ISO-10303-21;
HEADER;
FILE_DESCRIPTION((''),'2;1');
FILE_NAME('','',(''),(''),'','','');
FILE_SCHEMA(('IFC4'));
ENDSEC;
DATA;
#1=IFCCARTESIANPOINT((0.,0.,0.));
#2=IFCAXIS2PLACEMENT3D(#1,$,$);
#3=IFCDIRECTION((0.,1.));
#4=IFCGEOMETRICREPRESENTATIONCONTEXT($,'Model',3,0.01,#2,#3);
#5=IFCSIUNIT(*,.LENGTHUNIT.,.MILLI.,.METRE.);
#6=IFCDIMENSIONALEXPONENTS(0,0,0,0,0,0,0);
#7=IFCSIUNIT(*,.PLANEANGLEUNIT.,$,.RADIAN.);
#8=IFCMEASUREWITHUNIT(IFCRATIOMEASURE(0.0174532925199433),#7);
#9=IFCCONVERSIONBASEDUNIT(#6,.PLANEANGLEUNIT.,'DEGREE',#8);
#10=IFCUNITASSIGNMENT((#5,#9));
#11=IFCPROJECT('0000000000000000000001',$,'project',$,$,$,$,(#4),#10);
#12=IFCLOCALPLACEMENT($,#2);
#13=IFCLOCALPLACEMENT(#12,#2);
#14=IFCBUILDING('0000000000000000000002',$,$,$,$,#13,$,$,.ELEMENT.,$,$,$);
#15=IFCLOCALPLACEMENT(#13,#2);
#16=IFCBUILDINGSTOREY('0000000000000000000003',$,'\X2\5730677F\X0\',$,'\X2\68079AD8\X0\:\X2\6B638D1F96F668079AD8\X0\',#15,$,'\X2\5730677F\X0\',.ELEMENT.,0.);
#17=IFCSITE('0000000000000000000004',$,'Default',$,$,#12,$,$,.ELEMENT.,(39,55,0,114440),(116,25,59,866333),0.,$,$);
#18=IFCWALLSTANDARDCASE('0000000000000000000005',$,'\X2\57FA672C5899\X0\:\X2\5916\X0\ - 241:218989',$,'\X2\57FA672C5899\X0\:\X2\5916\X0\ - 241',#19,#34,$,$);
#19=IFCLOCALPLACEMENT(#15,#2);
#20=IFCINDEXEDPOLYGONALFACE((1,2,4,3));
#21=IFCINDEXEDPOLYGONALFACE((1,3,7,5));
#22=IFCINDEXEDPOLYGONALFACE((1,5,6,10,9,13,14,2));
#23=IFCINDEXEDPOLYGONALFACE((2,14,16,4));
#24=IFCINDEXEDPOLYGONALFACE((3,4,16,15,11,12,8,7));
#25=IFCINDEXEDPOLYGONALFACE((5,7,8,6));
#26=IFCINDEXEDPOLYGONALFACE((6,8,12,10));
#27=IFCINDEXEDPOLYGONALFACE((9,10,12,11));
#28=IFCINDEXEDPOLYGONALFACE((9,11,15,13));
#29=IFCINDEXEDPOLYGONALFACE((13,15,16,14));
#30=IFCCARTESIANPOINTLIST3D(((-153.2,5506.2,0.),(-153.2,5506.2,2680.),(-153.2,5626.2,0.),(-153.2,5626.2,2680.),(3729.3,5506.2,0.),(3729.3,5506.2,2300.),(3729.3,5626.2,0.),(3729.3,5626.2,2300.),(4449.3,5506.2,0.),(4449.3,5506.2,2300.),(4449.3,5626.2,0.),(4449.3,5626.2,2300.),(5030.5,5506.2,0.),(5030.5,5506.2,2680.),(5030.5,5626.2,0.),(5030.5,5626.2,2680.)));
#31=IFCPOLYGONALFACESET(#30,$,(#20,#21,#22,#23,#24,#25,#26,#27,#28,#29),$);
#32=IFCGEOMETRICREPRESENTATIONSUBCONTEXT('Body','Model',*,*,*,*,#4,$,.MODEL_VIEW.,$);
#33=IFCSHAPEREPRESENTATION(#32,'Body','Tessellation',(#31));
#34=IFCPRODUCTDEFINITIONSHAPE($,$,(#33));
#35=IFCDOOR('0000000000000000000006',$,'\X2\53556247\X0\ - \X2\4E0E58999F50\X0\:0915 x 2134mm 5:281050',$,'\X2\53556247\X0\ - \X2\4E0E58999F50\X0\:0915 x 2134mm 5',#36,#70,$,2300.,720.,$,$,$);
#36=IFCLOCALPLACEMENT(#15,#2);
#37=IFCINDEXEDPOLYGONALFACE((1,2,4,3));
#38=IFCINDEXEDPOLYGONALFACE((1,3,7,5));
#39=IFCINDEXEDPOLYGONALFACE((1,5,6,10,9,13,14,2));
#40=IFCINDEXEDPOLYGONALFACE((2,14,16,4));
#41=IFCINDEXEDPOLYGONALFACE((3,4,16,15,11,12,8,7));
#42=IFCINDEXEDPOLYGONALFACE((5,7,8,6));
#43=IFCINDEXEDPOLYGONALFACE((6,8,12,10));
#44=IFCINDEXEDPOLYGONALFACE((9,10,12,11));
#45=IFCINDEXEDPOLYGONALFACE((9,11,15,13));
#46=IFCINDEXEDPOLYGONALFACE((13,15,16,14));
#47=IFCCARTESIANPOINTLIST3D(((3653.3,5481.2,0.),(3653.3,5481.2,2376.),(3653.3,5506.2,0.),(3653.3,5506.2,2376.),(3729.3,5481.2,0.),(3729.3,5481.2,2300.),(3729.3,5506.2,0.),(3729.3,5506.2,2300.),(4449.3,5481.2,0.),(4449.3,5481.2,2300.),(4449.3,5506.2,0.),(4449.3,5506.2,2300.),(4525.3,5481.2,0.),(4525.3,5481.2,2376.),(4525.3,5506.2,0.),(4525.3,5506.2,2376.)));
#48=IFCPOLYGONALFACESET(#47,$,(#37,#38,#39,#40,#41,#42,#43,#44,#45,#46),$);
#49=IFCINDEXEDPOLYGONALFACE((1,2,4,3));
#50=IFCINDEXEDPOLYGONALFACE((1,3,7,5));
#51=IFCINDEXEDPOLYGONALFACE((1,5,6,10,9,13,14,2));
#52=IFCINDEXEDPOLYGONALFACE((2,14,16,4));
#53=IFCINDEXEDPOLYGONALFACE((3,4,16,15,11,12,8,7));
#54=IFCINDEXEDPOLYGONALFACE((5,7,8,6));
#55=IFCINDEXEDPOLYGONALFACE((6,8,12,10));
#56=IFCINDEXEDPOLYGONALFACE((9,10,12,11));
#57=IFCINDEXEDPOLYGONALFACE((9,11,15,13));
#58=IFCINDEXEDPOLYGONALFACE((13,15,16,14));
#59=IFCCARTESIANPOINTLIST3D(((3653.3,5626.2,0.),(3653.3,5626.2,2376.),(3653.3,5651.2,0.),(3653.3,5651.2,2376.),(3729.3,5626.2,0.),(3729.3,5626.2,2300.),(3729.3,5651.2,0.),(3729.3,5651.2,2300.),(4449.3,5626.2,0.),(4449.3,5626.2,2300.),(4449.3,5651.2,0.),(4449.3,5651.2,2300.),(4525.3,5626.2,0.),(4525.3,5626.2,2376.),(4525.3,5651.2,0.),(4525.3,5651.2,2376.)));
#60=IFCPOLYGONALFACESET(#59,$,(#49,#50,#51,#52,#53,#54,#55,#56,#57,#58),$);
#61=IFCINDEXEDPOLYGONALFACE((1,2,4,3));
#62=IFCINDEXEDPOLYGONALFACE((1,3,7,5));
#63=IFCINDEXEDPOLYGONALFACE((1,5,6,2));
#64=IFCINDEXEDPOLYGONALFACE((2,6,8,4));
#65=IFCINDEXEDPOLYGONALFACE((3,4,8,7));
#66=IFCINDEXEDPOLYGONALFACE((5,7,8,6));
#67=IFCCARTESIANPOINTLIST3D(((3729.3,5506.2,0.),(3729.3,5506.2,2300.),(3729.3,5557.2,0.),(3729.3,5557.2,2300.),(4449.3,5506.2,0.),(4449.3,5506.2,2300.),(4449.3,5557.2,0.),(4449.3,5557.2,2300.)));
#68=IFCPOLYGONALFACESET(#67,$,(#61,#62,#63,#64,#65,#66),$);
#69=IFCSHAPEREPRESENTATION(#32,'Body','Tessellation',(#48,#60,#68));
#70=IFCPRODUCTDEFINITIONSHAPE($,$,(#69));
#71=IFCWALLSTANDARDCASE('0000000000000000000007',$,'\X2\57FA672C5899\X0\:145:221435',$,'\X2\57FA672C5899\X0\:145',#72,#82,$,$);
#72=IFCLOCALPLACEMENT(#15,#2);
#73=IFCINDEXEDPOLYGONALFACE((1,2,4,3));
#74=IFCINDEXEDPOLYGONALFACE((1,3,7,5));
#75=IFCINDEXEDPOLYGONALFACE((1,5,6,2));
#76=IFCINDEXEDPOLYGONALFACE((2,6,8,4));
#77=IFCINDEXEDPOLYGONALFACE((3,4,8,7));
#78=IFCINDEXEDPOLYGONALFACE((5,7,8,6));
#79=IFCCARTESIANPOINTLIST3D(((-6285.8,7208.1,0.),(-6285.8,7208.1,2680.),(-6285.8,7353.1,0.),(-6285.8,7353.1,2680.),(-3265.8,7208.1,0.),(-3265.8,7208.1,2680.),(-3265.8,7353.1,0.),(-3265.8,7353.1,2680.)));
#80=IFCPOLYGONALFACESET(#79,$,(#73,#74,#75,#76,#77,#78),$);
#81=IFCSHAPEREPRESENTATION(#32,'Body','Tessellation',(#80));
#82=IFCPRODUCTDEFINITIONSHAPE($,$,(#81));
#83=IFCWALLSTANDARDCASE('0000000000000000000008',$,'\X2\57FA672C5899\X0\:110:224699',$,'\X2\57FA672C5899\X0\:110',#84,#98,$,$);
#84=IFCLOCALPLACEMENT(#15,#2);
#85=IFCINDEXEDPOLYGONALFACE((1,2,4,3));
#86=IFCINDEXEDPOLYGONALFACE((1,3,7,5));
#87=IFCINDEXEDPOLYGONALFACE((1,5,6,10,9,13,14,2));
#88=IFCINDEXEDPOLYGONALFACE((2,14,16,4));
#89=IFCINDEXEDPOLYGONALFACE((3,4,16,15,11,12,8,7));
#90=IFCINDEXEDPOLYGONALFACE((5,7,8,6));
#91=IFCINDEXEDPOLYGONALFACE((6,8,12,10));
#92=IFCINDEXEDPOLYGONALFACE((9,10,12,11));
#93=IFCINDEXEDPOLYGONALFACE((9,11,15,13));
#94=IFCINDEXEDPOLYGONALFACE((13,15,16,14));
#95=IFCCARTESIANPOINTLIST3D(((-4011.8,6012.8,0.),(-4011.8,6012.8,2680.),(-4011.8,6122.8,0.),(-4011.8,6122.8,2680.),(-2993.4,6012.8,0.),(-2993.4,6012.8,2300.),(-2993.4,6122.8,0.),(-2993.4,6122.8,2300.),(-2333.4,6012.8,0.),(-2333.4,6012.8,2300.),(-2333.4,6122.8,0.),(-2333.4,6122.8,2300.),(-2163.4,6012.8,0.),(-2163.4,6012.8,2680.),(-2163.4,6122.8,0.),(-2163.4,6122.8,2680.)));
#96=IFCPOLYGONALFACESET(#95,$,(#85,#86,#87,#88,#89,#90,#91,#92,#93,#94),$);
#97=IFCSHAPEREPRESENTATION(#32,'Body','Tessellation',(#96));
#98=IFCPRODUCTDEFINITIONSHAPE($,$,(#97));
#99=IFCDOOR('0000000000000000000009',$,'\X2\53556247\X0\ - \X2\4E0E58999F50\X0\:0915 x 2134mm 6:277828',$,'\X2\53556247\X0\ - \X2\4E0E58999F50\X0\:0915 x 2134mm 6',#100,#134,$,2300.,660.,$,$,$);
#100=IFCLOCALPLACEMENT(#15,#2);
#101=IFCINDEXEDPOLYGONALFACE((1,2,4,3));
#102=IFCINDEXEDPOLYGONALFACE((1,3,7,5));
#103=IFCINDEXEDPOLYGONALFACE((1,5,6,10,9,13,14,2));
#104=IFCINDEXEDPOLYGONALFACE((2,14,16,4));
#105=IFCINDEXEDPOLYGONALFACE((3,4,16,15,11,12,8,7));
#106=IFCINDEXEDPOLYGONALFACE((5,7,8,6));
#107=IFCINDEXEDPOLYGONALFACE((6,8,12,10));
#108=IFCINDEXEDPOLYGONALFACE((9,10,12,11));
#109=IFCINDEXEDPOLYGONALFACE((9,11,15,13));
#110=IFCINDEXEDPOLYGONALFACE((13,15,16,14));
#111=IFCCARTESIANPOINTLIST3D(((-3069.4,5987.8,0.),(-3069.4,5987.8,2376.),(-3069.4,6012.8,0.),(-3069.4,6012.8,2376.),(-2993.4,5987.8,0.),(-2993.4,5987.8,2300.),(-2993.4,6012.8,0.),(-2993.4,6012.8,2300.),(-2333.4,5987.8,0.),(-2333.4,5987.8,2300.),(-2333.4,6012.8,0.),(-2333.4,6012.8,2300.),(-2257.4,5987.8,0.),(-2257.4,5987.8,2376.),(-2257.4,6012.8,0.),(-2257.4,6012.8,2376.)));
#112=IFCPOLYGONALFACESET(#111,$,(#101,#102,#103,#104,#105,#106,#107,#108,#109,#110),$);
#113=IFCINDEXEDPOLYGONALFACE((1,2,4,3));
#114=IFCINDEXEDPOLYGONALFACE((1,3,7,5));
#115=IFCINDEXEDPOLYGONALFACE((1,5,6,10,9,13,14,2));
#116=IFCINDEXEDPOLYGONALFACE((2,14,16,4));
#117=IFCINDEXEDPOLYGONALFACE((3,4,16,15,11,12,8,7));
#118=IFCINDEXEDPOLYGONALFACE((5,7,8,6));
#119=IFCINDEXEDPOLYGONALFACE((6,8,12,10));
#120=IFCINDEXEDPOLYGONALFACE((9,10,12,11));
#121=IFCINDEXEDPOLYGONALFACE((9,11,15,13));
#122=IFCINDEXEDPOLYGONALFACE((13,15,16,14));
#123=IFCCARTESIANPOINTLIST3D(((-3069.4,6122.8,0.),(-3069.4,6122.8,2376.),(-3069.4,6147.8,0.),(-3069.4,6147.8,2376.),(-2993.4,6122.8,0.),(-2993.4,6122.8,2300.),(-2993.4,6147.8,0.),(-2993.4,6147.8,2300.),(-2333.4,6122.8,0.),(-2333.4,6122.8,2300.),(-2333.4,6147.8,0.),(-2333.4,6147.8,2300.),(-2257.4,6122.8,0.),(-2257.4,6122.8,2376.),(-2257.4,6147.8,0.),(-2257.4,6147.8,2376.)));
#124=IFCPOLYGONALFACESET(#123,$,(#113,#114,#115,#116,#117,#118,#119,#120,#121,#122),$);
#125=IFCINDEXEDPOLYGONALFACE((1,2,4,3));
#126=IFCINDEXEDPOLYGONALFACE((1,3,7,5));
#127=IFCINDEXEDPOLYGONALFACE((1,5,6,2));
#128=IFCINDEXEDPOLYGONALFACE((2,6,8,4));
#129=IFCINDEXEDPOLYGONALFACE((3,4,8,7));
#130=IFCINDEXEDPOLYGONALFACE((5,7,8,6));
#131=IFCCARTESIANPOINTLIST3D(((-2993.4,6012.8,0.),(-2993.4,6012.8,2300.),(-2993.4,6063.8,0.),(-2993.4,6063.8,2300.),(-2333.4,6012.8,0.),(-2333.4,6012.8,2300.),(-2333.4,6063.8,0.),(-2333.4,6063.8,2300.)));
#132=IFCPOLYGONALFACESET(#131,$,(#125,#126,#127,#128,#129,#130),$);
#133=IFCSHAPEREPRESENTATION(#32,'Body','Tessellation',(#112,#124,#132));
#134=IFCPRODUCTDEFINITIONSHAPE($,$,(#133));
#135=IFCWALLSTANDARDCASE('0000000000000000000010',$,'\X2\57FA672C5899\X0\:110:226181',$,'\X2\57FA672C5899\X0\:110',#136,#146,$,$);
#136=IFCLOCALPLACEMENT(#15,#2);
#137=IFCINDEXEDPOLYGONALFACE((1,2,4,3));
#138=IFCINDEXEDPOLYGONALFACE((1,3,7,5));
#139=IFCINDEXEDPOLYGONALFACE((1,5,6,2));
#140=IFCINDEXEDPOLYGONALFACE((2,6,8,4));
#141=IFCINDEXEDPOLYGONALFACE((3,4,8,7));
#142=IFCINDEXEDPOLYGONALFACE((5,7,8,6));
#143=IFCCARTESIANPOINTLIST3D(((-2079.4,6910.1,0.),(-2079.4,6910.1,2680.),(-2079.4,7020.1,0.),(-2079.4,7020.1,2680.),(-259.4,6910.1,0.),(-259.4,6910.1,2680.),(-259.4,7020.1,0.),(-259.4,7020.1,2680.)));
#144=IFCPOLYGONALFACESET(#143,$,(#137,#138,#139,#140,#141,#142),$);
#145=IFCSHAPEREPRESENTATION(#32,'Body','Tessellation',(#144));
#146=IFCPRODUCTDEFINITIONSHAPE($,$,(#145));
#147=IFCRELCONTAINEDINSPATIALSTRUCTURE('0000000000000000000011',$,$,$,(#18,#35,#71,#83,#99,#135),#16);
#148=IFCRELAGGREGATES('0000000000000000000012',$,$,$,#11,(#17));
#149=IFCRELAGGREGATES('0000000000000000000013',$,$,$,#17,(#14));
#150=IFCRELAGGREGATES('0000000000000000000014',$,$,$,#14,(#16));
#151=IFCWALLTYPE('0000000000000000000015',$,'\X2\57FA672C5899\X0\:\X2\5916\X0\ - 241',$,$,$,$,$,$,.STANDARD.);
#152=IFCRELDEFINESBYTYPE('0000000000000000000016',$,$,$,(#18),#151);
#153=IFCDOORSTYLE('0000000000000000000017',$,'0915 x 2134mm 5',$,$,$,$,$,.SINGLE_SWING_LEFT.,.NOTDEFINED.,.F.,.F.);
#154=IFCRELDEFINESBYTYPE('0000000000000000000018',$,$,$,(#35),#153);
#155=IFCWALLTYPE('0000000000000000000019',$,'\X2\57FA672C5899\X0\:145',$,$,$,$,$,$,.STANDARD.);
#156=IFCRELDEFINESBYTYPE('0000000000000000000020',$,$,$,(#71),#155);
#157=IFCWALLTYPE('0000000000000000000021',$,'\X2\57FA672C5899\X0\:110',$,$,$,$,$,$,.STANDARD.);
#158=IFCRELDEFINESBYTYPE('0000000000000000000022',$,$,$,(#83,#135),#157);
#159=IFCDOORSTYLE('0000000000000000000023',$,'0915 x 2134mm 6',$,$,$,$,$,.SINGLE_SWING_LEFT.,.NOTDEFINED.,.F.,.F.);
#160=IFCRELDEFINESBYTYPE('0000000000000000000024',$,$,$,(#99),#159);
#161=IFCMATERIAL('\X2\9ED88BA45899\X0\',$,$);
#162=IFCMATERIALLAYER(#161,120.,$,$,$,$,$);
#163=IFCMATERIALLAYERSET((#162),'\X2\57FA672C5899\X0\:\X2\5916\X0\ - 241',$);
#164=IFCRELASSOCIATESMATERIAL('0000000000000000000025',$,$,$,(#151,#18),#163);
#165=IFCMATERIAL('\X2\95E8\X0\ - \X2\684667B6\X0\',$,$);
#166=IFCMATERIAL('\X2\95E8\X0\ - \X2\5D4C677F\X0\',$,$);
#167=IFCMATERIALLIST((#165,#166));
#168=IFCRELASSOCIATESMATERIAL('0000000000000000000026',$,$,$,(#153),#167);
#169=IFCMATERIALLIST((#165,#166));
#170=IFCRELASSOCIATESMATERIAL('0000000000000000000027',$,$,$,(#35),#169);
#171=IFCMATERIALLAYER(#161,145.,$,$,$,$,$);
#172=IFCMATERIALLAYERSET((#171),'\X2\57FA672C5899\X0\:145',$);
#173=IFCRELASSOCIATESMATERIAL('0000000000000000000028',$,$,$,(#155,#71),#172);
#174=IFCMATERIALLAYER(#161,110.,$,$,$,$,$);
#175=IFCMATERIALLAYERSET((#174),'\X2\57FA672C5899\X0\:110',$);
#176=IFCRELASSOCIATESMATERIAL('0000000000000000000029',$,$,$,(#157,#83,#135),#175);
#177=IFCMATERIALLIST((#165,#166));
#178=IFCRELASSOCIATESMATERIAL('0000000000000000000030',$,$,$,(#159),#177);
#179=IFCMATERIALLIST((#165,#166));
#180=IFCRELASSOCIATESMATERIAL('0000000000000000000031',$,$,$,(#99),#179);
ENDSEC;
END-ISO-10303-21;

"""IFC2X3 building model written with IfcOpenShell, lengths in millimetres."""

from ifc_helpers import new_model, entity, si_unit, converted_unit, direction, frame, frame_2d, origin, origin_2d_with_axis, place, context, subcontext, project, spatial, polyline, rectangle, outline, extrude, source, transform, mapped, material, material_list, layer, layer_set, layer_usage, type_object, type_shapes, element, fill, save


model = new_model("IFC2X3")

# Units and contexts
model_context = context("Model", 3, precision=0.01, world=origin(), true_north=direction((0.0, 1.0)))
body_context = subcontext(model_context, "Body", "Model", "MODEL_VIEW")
ifc_project = project(units=[si_unit("LENGTHUNIT", "METRE", prefix="MILLI"), converted_unit("PLANEANGLEUNIT", "DEGREE", entity("IfcRatioMeasure", 0.0174532925199433), si_unit("PLANEANGLEUNIT", "RADIAN"), dimensions=[0, 0, 0, 0, 0, 0, 0])], contexts=[model_context])

# Site, building, storey
site_placement = place(None, origin())
site = spatial("IfcSite", under=ifc_project, at=site_placement, Name="Default", CompositionType="ELEMENT", RefLatitude=(39, 55, 0, 114440), RefLongitude=(116, 25, 59, 866333), RefElevation=0.0)
building_placement = place(site_placement, origin())
building = spatial("IfcBuilding", under=site, at=building_placement, CompositionType="ELEMENT")
storey_placement = place(building_placement, origin())
storey = spatial("IfcBuildingStorey", under=building, at=storey_placement, Name="地板", ObjectType="标高:正负零标高", LongName="地板", CompositionType="ELEMENT", Elevation=0.0)

# Shared definitions
ifc_material_1 = material(Name="默认墙")

# Wall, opening, door
ifc_layer_1 = layer(ifc_material_1, 120.0)
ifc_layer_set_1 = layer_set([ifc_layer_1], Name="基本墙:外 - 241")
ifc_layer_usage_1 = layer_usage(ifc_layer_set_1, "AXIS2", "NEGATIVE", 60.0)
wall_type_1 = type_object("IfcWallType", Name="基本墙:外 - 241", PredefinedType="STANDARD", material=ifc_layer_set_1)
wall_1_placement = place(storey_placement, frame((5030.5, 5566.2, 0.0), z_axis=(0.0, 0.0, 1.0), x_axis=(-1.0, 0.0, 0.0)))
wall_1 = element("IfcWallStandardCase", 1, at=wall_1_placement, inside=storey, type_object=wall_type_1, material=ifc_layer_usage_1, Name="基本墙:外 - 241:218989", ObjectType="基本墙:外 - 241", context=body_context, shape_type="SweptSolid", body=[
    extrude(rectangle(XDim=5183.7, YDim=120.0, at=frame_2d((2591.8, 0.0), x_axis=(-1.0, 0.0))), origin(), (0.0, 0.0, 1.0), 2680.0),
])
opening_1_placement = place(wall_1_placement, frame((581.2, -60.0, 0.0)))
opening_1 = element("IfcOpeningElement", 2, at=opening_1_placement, cuts=wall_1, ObjectType="Opening", context=body_context, shape_type="SweptSolid", body=[
    extrude(rectangle(XDim=720.0, YDim=2300.0, at=frame_2d((1150.0, 360.0), x_axis=(0.0, -1.0))), frame((0.0, 0.0, 0.0), z_axis=(0.0, 1.0, 0.0), x_axis=(0.0, 0.0, 1.0)), (0.0, 0.0, 1.0), 120.0),
])
ifc_material_2 = material(Name="门 - 框架")
ifc_material_3 = material(Name="门 - 嵌板")
ifc_material_list_1 = material_list([ifc_material_2, ifc_material_3])
ifc_material_list_2 = material_list([ifc_material_2, ifc_material_3])
door_style_1 = type_object("IfcDoorStyle", Name="0915 x 2134mm 5", ConstructionType="NOTDEFINED", OperationType="SINGLE_SWING_LEFT", ParameterTakesPrecedence=False, Sizeable=False, material=ifc_material_list_2)
shared_shape_1 = source(origin(), body_context, "Body", "SweptSolid", [
    extrude(outline(polyline([(-436.0, -1207.0), (436.0, -1207.0), (436.0, 1169.0), (360.0, 1169.0), (360.0, -1131.0), (-360.0, -1131.0), (-360.0, 1169.0), (-436.0, 1169.0), (-436.0, -1207.0)])), frame((360.0, 145.0, 1169.0), z_axis=(0.0, -1.0, 0.0), x_axis=(-1.0, 0.0, 0.0)), (0.0, 0.0, 1.0), 25.0),
    extrude(outline(polyline([(-1207.0, -436.0), (1169.0, -436.0), (1169.0, -360.0), (-1131.0, -360.0), (-1131.0, 360.0), (1169.0, 360.0), (1169.0, 436.0), (-1207.0, 436.0), (-1207.0, -436.0)])), frame((360.0, 0.0, 1169.0), z_axis=(0.0, -1.0, 0.0), x_axis=(0.0, 0.0, -1.0)), (0.0, 0.0, 1.0), 25.0),
    extrude(rectangle(XDim=720.0, YDim=51.0, at=frame_2d((0.0, 0.0), x_axis=(1.0, 0.0))), frame((360.0, 94.5, 0.0)), (0.0, 0.0, 1.0), 2300.0),
])
type_shapes(door_style_1, [shared_shape_1])
door_1_placement = place(opening_1_placement, origin())
door_1 = element("IfcDoor", 3, at=door_1_placement, inside=storey, type_object=door_style_1, material=ifc_material_list_1, Name="单扇 - 与墙齐:0915 x 2134mm 5:281050", ObjectType="单扇 - 与墙齐:0915 x 2134mm 5", OverallHeight=2300.0, OverallWidth=720.0, context=body_context, shape_type="MappedRepresentation", body=[
    mapped(shared_shape_1, transform((0.0, 0.0, 0.0), scale=1.0)),
])
fill(opening_1, door_1)

# Wall
ifc_layer_2 = layer(ifc_material_1, 145.0)
ifc_layer_set_2 = layer_set([ifc_layer_2], Name="基本墙:145")
ifc_layer_usage_2 = layer_usage(ifc_layer_set_2, "AXIS2", "NEGATIVE", 72.5)
wall_type_2 = type_object("IfcWallType", Name="基本墙:145", PredefinedType="STANDARD", material=ifc_layer_set_2)
wall_2_placement = place(storey_placement, frame((-3265.8, 7280.6, 0.0), z_axis=(0.0, 0.0, 1.0), x_axis=(-1.0, 0.0, 0.0)))
element("IfcWallStandardCase", 4, at=wall_2_placement, inside=storey, type_object=wall_type_2, material=ifc_layer_usage_2, Name="基本墙:145:221435", ObjectType="基本墙:145", context=body_context, shape_type="SweptSolid", body=[
    extrude(rectangle(XDim=3020.0, YDim=145.0, at=frame_2d((1510.0, 0.0), x_axis=(-1.0, 0.0))), origin(), (0.0, 0.0, 1.0), 2680.0),
])

# Wall, opening, door
ifc_layer_3 = layer(ifc_material_1, 110.0)
ifc_layer_set_3 = layer_set([ifc_layer_3], Name="基本墙:110")
ifc_layer_usage_3 = layer_usage(ifc_layer_set_3, "AXIS2", "NEGATIVE", 55.0)
wall_type_3 = type_object("IfcWallType", Name="基本墙:110", PredefinedType="STANDARD", material=ifc_layer_set_3)
wall_3_placement = place(storey_placement, frame((-2163.4, 6067.8, 0.0), z_axis=(0.0, 0.0, 1.0), x_axis=(-1.0, 0.0, 0.0)))
wall_3 = element("IfcWallStandardCase", 5, at=wall_3_placement, inside=storey, type_object=wall_type_3, material=ifc_layer_usage_3, Name="基本墙:110:224699", ObjectType="基本墙:110", context=body_context, shape_type="SweptSolid", body=[
    extrude(rectangle(XDim=1848.4, YDim=110.0, at=frame_2d((924.2, 0.0), x_axis=(-1.0, 0.0))), origin(), (0.0, 0.0, 1.0), 2680.0),
])
opening_2_placement = place(wall_3_placement, frame((170.0, -55.0, 0.0)))
opening_2 = element("IfcOpeningElement", 6, at=opening_2_placement, cuts=wall_3, ObjectType="Opening", context=body_context, shape_type="SweptSolid", body=[
    extrude(rectangle(XDim=660.0, YDim=2300.0, at=frame_2d((1150.0, 330.0), x_axis=(0.0, -1.0))), frame((0.0, 0.0, 0.0), z_axis=(0.0, 1.0, 0.0), x_axis=(0.0, 0.0, 1.0)), (0.0, 0.0, 1.0), 110.0),
])
ifc_material_list_3 = material_list([ifc_material_2, ifc_material_3])
ifc_material_list_4 = material_list([ifc_material_2, ifc_material_3])
door_style_2 = type_object("IfcDoorStyle", Name="0915 x 2134mm 6", ConstructionType="NOTDEFINED", OperationType="SINGLE_SWING_LEFT", ParameterTakesPrecedence=False, Sizeable=False, material=ifc_material_list_4)
shared_shape_2 = source(origin(), body_context, "Body", "SweptSolid", [
    extrude(outline(polyline([(-406.0, -1207.0), (406.0, -1207.0), (406.0, 1169.0), (330.0, 1169.0), (330.0, -1131.0), (-330.0, -1131.0), (-330.0, 1169.0), (-406.0, 1169.0), (-406.0, -1207.0)])), frame((330.0, 135.0, 1169.0), z_axis=(0.0, -1.0, 0.0), x_axis=(-1.0, 0.0, 0.0)), (0.0, 0.0, 1.0), 25.0),
    extrude(outline(polyline([(-1207.0, -406.0), (1169.0, -406.0), (1169.0, -330.0), (-1131.0, -330.0), (-1131.0, 330.0), (1169.0, 330.0), (1169.0, 406.0), (-1207.0, 406.0), (-1207.0, -406.0)])), frame((330.0, 0.0, 1169.0), z_axis=(0.0, -1.0, 0.0), x_axis=(0.0, 0.0, -1.0)), (0.0, 0.0, 1.0), 25.0),
    extrude(rectangle(XDim=660.0, YDim=51.0, at=origin_2d_with_axis()), frame((330.0, 84.5, 0.0)), (0.0, 0.0, 1.0), 2300.0),
])
type_shapes(door_style_2, [shared_shape_2])
door_2_placement = place(opening_2_placement, origin())
door_2 = element("IfcDoor", 7, at=door_2_placement, inside=storey, type_object=door_style_2, material=ifc_material_list_3, Name="单扇 - 与墙齐:0915 x 2134mm 6:277828", ObjectType="单扇 - 与墙齐:0915 x 2134mm 6", OverallHeight=2300.0, OverallWidth=660.0, context=body_context, shape_type="MappedRepresentation", body=[
    mapped(shared_shape_2, transform((0.0, 0.0, 0.0), scale=1.0)),
])
fill(opening_2, door_2)

# Wall
ifc_layer_usage_4 = layer_usage(ifc_layer_set_3, "AXIS2", "NEGATIVE", 55.0)
wall_4_placement = place(storey_placement, frame((-2079.4, 6965.1, 0.0)))
element("IfcWallStandardCase", 8, at=wall_4_placement, inside=storey, type_object=wall_type_3, material=ifc_layer_usage_4, Name="基本墙:110:226181", ObjectType="基本墙:110", context=body_context, shape_type="SweptSolid", body=[
    extrude(rectangle(XDim=1820.0, YDim=110.0, at=frame_2d((910.0, 0.0), x_axis=(-1.0, 0.0))), origin(), (0.0, 0.0, 1.0), 2680.0),
])

save(model, "model.ifc")
